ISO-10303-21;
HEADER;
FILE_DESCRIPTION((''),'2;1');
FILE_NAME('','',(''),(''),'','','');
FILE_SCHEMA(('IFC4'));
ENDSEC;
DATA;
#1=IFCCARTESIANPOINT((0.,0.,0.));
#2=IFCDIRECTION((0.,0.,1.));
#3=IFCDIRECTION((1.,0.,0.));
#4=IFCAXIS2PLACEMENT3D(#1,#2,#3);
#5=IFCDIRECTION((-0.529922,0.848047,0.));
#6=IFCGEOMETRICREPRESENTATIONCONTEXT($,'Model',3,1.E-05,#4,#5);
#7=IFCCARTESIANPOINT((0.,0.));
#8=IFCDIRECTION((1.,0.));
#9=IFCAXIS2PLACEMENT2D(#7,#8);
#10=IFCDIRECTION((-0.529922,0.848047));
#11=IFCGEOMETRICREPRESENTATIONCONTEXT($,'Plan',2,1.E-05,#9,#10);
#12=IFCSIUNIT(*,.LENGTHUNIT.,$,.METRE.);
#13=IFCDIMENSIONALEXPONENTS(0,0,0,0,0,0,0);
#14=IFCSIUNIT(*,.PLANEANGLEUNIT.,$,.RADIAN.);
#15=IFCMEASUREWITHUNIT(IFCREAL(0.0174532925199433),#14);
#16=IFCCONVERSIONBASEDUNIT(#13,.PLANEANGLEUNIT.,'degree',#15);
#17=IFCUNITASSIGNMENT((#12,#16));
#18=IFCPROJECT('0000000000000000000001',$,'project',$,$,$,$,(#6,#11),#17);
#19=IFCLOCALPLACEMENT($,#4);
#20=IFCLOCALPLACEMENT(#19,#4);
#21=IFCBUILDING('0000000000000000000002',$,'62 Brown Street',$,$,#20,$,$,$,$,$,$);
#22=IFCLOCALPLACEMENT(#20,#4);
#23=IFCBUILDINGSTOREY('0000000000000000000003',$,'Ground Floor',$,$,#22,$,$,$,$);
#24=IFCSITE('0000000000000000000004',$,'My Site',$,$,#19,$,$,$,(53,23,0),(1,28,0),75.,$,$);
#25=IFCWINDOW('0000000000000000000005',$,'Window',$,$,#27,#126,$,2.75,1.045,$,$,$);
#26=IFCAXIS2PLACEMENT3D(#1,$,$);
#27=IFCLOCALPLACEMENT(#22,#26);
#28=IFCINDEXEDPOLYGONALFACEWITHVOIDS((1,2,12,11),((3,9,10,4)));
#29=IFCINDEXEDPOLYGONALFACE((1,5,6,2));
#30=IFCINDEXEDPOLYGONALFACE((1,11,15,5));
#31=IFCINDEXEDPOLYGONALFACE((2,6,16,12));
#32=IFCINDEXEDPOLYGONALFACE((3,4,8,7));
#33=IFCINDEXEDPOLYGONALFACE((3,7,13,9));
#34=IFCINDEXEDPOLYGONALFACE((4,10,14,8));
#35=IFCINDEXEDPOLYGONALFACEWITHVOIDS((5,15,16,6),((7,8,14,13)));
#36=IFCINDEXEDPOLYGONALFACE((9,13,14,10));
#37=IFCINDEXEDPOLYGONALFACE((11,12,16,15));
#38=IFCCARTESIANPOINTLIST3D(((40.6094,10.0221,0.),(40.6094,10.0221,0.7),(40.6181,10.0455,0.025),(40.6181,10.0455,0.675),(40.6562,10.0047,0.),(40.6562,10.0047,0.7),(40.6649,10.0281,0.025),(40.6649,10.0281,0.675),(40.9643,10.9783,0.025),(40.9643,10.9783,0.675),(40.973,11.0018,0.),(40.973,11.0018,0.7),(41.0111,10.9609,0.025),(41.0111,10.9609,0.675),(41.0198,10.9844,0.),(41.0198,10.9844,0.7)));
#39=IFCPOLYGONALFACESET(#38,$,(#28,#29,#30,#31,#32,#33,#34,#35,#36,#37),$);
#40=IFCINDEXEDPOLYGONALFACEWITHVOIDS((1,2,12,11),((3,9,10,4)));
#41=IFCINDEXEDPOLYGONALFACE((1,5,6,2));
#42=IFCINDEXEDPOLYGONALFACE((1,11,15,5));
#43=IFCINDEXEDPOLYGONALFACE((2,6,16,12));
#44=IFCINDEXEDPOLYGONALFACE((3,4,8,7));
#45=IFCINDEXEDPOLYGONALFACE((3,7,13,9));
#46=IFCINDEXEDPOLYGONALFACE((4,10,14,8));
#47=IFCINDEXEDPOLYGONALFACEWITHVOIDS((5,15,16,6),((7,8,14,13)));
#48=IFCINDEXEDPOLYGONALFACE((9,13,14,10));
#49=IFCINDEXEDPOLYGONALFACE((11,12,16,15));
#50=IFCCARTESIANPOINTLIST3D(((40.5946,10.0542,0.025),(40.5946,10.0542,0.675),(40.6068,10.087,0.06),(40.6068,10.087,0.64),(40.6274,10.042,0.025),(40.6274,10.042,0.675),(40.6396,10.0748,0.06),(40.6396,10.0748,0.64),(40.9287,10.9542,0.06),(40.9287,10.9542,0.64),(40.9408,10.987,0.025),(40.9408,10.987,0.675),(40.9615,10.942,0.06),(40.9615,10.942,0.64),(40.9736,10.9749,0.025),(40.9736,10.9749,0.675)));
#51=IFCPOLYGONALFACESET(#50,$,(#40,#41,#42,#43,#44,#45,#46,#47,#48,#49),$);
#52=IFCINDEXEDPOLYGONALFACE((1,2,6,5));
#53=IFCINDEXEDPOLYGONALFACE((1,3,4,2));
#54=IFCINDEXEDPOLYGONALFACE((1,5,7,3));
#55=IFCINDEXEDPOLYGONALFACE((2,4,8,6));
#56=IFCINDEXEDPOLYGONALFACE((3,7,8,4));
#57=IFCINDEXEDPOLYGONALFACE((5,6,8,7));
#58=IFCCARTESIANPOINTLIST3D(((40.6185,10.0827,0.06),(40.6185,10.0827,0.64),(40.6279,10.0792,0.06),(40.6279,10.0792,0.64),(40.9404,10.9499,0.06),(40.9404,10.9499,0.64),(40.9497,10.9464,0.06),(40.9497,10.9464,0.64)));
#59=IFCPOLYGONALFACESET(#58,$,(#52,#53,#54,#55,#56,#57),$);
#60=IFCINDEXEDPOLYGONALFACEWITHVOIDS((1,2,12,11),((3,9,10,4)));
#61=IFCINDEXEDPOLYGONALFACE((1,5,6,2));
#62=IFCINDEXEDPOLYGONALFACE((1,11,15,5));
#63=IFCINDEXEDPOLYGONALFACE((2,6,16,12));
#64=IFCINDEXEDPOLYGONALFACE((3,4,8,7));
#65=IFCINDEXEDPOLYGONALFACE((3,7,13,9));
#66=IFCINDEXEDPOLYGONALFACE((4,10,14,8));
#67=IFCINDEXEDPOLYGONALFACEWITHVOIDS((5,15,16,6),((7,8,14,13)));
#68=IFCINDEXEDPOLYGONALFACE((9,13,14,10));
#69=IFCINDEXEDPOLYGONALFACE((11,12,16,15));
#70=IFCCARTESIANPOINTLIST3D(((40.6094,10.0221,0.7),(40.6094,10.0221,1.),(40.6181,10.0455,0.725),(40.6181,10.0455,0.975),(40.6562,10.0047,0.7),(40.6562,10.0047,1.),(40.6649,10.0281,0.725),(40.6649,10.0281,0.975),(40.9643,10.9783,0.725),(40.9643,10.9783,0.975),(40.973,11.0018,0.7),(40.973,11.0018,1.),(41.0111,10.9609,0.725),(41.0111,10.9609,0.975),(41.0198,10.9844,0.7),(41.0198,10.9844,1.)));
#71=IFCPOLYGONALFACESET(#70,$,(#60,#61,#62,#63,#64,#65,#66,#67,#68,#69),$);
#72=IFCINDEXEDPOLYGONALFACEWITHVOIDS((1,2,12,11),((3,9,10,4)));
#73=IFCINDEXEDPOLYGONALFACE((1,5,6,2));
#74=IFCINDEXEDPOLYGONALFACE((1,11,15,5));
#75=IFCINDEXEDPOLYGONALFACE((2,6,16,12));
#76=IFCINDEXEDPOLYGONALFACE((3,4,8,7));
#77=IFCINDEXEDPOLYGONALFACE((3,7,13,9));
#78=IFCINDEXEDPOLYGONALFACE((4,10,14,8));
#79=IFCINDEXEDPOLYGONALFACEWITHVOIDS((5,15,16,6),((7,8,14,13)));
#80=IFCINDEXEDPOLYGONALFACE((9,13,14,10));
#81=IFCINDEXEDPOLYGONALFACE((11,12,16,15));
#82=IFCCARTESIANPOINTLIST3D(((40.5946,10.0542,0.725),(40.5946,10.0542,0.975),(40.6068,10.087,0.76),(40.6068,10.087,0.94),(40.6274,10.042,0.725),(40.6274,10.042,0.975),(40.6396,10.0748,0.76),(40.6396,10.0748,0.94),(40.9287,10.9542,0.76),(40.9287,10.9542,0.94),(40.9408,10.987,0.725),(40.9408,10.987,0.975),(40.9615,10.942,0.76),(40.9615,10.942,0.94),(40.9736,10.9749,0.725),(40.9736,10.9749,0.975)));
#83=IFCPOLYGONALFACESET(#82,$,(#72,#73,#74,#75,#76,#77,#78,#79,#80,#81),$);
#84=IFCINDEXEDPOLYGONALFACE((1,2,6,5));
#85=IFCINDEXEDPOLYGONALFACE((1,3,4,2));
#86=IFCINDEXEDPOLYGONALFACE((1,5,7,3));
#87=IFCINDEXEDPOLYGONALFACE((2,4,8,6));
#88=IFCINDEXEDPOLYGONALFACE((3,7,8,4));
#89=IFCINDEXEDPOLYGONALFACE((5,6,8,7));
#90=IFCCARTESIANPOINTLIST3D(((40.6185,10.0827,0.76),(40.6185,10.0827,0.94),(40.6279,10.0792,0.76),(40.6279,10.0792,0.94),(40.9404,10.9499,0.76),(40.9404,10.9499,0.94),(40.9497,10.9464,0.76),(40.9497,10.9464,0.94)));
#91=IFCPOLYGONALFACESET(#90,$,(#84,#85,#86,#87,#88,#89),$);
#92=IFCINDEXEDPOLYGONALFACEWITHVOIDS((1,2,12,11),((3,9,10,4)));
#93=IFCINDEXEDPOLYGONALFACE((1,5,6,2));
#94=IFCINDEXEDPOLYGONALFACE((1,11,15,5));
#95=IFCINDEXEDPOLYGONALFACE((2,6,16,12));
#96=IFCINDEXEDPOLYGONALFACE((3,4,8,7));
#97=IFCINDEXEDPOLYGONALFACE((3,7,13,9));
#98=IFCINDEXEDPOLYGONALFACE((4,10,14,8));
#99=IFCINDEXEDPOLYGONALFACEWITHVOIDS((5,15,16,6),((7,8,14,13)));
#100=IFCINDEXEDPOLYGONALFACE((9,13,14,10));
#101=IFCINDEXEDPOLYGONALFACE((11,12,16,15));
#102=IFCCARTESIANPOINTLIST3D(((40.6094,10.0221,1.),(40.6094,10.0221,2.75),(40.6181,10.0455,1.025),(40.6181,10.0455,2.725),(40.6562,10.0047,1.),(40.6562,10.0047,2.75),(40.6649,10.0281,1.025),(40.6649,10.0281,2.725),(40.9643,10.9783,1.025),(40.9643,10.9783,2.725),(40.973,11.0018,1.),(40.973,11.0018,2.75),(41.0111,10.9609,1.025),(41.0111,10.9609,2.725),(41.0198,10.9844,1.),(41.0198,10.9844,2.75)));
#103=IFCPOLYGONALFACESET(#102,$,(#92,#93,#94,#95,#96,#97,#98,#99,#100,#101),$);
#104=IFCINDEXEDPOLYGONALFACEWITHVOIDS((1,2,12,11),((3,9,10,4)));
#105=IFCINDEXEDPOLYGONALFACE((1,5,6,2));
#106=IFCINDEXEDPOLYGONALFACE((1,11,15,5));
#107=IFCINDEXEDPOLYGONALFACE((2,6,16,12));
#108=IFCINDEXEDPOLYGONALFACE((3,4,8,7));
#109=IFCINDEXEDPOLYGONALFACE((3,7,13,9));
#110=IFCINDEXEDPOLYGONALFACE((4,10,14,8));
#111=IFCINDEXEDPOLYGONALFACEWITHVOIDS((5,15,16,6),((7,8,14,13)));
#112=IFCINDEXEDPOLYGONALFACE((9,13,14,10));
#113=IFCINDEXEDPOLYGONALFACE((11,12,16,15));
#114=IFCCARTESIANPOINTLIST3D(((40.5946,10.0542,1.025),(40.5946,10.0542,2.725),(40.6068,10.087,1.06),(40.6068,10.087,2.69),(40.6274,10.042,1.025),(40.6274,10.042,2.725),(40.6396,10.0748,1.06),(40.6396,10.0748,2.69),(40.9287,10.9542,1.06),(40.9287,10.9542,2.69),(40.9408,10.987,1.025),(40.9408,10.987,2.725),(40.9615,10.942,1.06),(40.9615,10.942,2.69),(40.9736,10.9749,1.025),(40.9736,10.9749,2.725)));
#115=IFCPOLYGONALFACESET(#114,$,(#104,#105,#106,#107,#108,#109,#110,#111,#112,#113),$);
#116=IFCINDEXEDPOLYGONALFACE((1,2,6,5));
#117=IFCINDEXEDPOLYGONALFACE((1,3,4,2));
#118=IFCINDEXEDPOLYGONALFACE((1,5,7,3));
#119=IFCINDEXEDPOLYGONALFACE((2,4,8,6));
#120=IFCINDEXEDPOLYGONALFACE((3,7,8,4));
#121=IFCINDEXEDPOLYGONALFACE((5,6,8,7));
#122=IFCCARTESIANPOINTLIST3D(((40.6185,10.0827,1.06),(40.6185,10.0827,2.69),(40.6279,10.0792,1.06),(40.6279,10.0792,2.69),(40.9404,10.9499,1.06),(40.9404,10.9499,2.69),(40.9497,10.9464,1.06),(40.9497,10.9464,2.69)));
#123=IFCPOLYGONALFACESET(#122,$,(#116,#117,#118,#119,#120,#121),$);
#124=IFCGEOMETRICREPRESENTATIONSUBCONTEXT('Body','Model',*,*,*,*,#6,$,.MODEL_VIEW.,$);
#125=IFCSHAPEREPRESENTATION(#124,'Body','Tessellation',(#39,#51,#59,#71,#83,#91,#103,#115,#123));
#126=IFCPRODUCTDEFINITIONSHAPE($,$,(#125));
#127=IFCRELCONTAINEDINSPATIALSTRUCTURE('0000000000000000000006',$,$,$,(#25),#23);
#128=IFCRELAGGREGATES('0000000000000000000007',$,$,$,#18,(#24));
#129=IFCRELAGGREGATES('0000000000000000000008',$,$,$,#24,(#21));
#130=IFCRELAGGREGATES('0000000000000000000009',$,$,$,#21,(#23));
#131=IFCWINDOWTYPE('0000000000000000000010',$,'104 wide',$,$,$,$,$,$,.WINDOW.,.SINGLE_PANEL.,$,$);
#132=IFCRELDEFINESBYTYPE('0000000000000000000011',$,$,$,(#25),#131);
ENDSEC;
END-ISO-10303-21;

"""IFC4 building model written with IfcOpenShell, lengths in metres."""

from ifc_helpers import new_model, entity, si_unit, converted_unit, direction, frame, origin_with_axes, origin_2d_with_axis, place, context, subcontext, project, spatial, line, indexed_curve, outline, extrude, shape, source, transform, mapped, type_object, type_shapes, element, save


model = new_model("IFC4")

# Units and contexts
model_context = context("Model", 3, precision=1e-05, world=origin_with_axes(), true_north=direction((-0.529922, 0.848047, 0.0)))
plan_context = context("Plan", 2, precision=1e-05, world=origin_2d_with_axis(), true_north=direction((-0.529922, 0.848047)))
body_context_1 = subcontext(model_context, "Body", "Model", "MODEL_VIEW")
body_context_2 = subcontext(plan_context, "Body", "Plan", "PLAN_VIEW")
ifc_project = project(units=[si_unit("LENGTHUNIT", "METRE"), converted_unit("PLANEANGLEUNIT", "degree", entity("IfcReal", 0.0174532925199433), si_unit("PLANEANGLEUNIT", "RADIAN"), dimensions=[0, 0, 0, 0, 0, 0, 0])], contexts=[model_context, plan_context])

# Site, building, storey
site_placement = place(None, origin_with_axes())
site = spatial("IfcSite", under=ifc_project, at=site_placement, Name="My Site", RefLatitude=(53, 23, 0), RefLongitude=(1, 28, 0), RefElevation=75.0)
building_placement = place(site_placement, origin_with_axes())
building = spatial("IfcBuilding", under=site, at=building_placement, Name="62 Brown Street")
storey_placement = place(building_placement, origin_with_axes())
storey = spatial("IfcBuildingStorey", under=building, at=storey_placement, Name="Ground Floor")

# Window
window_type_1 = type_object("IfcWindowType", Name="104 wide", PartitioningType="SINGLE_PANEL", PredefinedType="WINDOW")
shared_shape_1 = source(origin_with_axes(), body_context_1, "Body", "SweptSolid", [
    extrude(outline(indexed_curve([(0.0, 0.0), (1.045, 0.0), (1.045, 0.7), (0.0, 0.7)], segments=[line(1, 2, 3, 4, 1)]), holes=[indexed_curve([(0.025, 0.025), (1.02, 0.025), (1.02, 0.675), (0.025, 0.675)], segments=[line(1, 2, 3, 4, 1)])]), frame((0.0, 0.15, 0.0), z_axis=(0.0, -1.0, 0.0), x_axis=(1.0, 0.0, 0.0)), (0.0, 0.0, -1.0), 0.05),
    extrude(outline(indexed_curve([(0.0, 0.0), (0.995, 0.0), (0.995, 0.65), (0.0, 0.65)], segments=[line(1, 2, 3, 4, 1)]), holes=[indexed_curve([(0.035, 0.035), (0.96, 0.035), (0.96, 0.615), (0.035, 0.615)], segments=[line(1, 2, 3, 4, 1)])]), frame((0.025, 0.19, 0.025), z_axis=(0.0, -1.0, 0.0), x_axis=(1.0, 0.0, 0.0)), (0.0, 0.0, -1.0), 0.035),
    extrude(outline(indexed_curve([(0.035, 0.035), (0.96, 0.035), (0.96, 0.615), (0.035, 0.615)], segments=[line(1, 2, 3, 4, 1)])), frame((0.025, 0.2025, 0.025), z_axis=(0.0, -1.0, 0.0), x_axis=(1.0, 0.0, 0.0)), (0.0, 0.0, -1.0), 0.01),
    extrude(outline(indexed_curve([(0.0, 0.0), (1.045, 0.0), (1.045, 0.3), (0.0, 0.3)], segments=[line(1, 2, 3, 4, 1)]), holes=[indexed_curve([(0.025, 0.025), (1.02, 0.025), (1.02, 0.275), (0.025, 0.275)], segments=[line(1, 2, 3, 4, 1)])]), frame((0.0, 0.15, 0.7), z_axis=(0.0, -1.0, 0.0), x_axis=(1.0, 0.0, 0.0)), (0.0, 0.0, -1.0), 0.05),
    extrude(outline(indexed_curve([(0.0, 0.0), (0.995, 0.0), (0.995, 0.25), (0.0, 0.25)], segments=[line(1, 2, 3, 4, 1)]), holes=[indexed_curve([(0.035, 0.035), (0.96, 0.035), (0.96, 0.215), (0.035, 0.215)], segments=[line(1, 2, 3, 4, 1)])]), frame((0.025, 0.19, 0.725), z_axis=(0.0, -1.0, 0.0), x_axis=(1.0, 0.0, 0.0)), (0.0, 0.0, -1.0), 0.035),
    extrude(outline(indexed_curve([(0.035, 0.035), (0.96, 0.035), (0.96, 0.215), (0.035, 0.215)], segments=[line(1, 2, 3, 4, 1)])), frame((0.025, 0.2025, 0.725), z_axis=(0.0, -1.0, 0.0), x_axis=(1.0, 0.0, 0.0)), (0.0, 0.0, -1.0), 0.01),
    extrude(outline(indexed_curve([(0.0, 0.0), (1.045, 0.0), (1.045, 1.75), (0.0, 1.75)], segments=[line(1, 2, 3, 4, 1)]), holes=[indexed_curve([(0.025, 0.025), (1.02, 0.025), (1.02, 1.725), (0.025, 1.725)], segments=[line(1, 2, 3, 4, 1)])]), frame((0.0, 0.15, 1.0), z_axis=(0.0, -1.0, 0.0), x_axis=(1.0, 0.0, 0.0)), (0.0, 0.0, -1.0), 0.05),
    extrude(outline(indexed_curve([(0.0, 0.0), (0.995, 0.0), (0.995, 1.7), (0.0, 1.7)], segments=[line(1, 2, 3, 4, 1)]), holes=[indexed_curve([(0.035, 0.035), (0.96, 0.035), (0.96, 1.665), (0.035, 1.665)], segments=[line(1, 2, 3, 4, 1)])]), frame((0.025, 0.19, 1.025), z_axis=(0.0, -1.0, 0.0), x_axis=(1.0, 0.0, 0.0)), (0.0, 0.0, -1.0), 0.035),
    extrude(outline(indexed_curve([(0.035, 0.035), (0.96, 0.035), (0.96, 1.665), (0.035, 1.665)], segments=[line(1, 2, 3, 4, 1)])), frame((0.025, 0.2025, 1.025), z_axis=(0.0, -1.0, 0.0), x_axis=(1.0, 0.0, 0.0)), (0.0, 0.0, -1.0), 0.01),
])
shared_shape_2 = source(origin_with_axes(), body_context_2, "Body", "Curve2D", [
    entity("IfcIndexedPolyCurve", entity("IfcCartesianPointList2D", [[0.025, 0.15], [1.02, 0.15]])),
    entity("IfcIndexedPolyCurve", entity("IfcCartesianPointList2D", [[0.0, 0.2], [0.025, 0.2], [0.025, 0.15], [0.0, 0.15]]), [entity("IfcLineIndex", [1, 2, 3, 4, 1])]),
    entity("IfcIndexedPolyCurve", entity("IfcCartesianPointList2D", [[1.045, 0.2], [1.02, 0.2], [1.02, 0.15], [1.045, 0.15]]), [entity("IfcLineIndex", [1, 2, 3, 4, 1])]),
    entity("IfcIndexedPolyCurve", entity("IfcCartesianPointList2D", [[0.025, 0.19], [0.06, 0.19], [0.06, 0.225], [0.025, 0.225]]), [entity("IfcLineIndex", [1, 2, 3, 4, 1])]),
    entity("IfcIndexedPolyCurve", entity("IfcCartesianPointList2D", [[1.02, 0.19], [0.985, 0.19], [0.985, 0.225], [1.02, 0.225]]), [entity("IfcLineIndex", [1, 2, 3, 4, 1])]),
    entity("IfcIndexedPolyCurve", entity("IfcCartesianPointList2D", [[0.06, 0.19], [0.985, 0.19]])),
    entity("IfcIndexedPolyCurve", entity("IfcCartesianPointList2D", [[0.06, 0.225], [0.985, 0.225]])),
    entity("IfcIndexedPolyCurve", entity("IfcCartesianPointList2D", [[0.06, 0.2075], [0.985, 0.2075]])),
])
type_shapes(window_type_1, [shared_shape_1, shared_shape_2])
placement_1 = place(storey_placement, frame((39.024, 5.1755, 0.0), z_axis=(0.0, 0.0, 1.0), x_axis=(0.347944, 0.937515, 0.0)))
placement_2 = place(placement_1, frame((5.0954, 0.0, 0.0), z_axis=(0.0, 0.0, 1.0), x_axis=(1.0, 0.0, 0.0)))
window_1_placement = place(placement_2, origin_with_axes())
element("IfcWindow", 1, at=window_1_placement, inside=storey, type_object=window_type_1, Name="Window", OverallHeight=2.75, OverallWidth=1.045, shapes=[
    shape(body_context_1, "Body", "MappedRepresentation", [mapped(shared_shape_1, transform((0.0, 0.0, 0.0), x_axis=(1.0, 0.0, 0.0), y_axis=(0.0, 1.0, 0.0), z_axis=(0.0, 0.0, 1.0), scale=1.0))]),
    shape(body_context_2, "Body", "MappedRepresentation", [mapped(shared_shape_2, transform((0.0, 0.0, 0.0), x_axis=(1.0, 0.0, 0.0), y_axis=(0.0, 1.0, 0.0), z_axis=(0.0, 0.0, 1.0), scale=1.0))]),
])

save(model, "model.ifc")
